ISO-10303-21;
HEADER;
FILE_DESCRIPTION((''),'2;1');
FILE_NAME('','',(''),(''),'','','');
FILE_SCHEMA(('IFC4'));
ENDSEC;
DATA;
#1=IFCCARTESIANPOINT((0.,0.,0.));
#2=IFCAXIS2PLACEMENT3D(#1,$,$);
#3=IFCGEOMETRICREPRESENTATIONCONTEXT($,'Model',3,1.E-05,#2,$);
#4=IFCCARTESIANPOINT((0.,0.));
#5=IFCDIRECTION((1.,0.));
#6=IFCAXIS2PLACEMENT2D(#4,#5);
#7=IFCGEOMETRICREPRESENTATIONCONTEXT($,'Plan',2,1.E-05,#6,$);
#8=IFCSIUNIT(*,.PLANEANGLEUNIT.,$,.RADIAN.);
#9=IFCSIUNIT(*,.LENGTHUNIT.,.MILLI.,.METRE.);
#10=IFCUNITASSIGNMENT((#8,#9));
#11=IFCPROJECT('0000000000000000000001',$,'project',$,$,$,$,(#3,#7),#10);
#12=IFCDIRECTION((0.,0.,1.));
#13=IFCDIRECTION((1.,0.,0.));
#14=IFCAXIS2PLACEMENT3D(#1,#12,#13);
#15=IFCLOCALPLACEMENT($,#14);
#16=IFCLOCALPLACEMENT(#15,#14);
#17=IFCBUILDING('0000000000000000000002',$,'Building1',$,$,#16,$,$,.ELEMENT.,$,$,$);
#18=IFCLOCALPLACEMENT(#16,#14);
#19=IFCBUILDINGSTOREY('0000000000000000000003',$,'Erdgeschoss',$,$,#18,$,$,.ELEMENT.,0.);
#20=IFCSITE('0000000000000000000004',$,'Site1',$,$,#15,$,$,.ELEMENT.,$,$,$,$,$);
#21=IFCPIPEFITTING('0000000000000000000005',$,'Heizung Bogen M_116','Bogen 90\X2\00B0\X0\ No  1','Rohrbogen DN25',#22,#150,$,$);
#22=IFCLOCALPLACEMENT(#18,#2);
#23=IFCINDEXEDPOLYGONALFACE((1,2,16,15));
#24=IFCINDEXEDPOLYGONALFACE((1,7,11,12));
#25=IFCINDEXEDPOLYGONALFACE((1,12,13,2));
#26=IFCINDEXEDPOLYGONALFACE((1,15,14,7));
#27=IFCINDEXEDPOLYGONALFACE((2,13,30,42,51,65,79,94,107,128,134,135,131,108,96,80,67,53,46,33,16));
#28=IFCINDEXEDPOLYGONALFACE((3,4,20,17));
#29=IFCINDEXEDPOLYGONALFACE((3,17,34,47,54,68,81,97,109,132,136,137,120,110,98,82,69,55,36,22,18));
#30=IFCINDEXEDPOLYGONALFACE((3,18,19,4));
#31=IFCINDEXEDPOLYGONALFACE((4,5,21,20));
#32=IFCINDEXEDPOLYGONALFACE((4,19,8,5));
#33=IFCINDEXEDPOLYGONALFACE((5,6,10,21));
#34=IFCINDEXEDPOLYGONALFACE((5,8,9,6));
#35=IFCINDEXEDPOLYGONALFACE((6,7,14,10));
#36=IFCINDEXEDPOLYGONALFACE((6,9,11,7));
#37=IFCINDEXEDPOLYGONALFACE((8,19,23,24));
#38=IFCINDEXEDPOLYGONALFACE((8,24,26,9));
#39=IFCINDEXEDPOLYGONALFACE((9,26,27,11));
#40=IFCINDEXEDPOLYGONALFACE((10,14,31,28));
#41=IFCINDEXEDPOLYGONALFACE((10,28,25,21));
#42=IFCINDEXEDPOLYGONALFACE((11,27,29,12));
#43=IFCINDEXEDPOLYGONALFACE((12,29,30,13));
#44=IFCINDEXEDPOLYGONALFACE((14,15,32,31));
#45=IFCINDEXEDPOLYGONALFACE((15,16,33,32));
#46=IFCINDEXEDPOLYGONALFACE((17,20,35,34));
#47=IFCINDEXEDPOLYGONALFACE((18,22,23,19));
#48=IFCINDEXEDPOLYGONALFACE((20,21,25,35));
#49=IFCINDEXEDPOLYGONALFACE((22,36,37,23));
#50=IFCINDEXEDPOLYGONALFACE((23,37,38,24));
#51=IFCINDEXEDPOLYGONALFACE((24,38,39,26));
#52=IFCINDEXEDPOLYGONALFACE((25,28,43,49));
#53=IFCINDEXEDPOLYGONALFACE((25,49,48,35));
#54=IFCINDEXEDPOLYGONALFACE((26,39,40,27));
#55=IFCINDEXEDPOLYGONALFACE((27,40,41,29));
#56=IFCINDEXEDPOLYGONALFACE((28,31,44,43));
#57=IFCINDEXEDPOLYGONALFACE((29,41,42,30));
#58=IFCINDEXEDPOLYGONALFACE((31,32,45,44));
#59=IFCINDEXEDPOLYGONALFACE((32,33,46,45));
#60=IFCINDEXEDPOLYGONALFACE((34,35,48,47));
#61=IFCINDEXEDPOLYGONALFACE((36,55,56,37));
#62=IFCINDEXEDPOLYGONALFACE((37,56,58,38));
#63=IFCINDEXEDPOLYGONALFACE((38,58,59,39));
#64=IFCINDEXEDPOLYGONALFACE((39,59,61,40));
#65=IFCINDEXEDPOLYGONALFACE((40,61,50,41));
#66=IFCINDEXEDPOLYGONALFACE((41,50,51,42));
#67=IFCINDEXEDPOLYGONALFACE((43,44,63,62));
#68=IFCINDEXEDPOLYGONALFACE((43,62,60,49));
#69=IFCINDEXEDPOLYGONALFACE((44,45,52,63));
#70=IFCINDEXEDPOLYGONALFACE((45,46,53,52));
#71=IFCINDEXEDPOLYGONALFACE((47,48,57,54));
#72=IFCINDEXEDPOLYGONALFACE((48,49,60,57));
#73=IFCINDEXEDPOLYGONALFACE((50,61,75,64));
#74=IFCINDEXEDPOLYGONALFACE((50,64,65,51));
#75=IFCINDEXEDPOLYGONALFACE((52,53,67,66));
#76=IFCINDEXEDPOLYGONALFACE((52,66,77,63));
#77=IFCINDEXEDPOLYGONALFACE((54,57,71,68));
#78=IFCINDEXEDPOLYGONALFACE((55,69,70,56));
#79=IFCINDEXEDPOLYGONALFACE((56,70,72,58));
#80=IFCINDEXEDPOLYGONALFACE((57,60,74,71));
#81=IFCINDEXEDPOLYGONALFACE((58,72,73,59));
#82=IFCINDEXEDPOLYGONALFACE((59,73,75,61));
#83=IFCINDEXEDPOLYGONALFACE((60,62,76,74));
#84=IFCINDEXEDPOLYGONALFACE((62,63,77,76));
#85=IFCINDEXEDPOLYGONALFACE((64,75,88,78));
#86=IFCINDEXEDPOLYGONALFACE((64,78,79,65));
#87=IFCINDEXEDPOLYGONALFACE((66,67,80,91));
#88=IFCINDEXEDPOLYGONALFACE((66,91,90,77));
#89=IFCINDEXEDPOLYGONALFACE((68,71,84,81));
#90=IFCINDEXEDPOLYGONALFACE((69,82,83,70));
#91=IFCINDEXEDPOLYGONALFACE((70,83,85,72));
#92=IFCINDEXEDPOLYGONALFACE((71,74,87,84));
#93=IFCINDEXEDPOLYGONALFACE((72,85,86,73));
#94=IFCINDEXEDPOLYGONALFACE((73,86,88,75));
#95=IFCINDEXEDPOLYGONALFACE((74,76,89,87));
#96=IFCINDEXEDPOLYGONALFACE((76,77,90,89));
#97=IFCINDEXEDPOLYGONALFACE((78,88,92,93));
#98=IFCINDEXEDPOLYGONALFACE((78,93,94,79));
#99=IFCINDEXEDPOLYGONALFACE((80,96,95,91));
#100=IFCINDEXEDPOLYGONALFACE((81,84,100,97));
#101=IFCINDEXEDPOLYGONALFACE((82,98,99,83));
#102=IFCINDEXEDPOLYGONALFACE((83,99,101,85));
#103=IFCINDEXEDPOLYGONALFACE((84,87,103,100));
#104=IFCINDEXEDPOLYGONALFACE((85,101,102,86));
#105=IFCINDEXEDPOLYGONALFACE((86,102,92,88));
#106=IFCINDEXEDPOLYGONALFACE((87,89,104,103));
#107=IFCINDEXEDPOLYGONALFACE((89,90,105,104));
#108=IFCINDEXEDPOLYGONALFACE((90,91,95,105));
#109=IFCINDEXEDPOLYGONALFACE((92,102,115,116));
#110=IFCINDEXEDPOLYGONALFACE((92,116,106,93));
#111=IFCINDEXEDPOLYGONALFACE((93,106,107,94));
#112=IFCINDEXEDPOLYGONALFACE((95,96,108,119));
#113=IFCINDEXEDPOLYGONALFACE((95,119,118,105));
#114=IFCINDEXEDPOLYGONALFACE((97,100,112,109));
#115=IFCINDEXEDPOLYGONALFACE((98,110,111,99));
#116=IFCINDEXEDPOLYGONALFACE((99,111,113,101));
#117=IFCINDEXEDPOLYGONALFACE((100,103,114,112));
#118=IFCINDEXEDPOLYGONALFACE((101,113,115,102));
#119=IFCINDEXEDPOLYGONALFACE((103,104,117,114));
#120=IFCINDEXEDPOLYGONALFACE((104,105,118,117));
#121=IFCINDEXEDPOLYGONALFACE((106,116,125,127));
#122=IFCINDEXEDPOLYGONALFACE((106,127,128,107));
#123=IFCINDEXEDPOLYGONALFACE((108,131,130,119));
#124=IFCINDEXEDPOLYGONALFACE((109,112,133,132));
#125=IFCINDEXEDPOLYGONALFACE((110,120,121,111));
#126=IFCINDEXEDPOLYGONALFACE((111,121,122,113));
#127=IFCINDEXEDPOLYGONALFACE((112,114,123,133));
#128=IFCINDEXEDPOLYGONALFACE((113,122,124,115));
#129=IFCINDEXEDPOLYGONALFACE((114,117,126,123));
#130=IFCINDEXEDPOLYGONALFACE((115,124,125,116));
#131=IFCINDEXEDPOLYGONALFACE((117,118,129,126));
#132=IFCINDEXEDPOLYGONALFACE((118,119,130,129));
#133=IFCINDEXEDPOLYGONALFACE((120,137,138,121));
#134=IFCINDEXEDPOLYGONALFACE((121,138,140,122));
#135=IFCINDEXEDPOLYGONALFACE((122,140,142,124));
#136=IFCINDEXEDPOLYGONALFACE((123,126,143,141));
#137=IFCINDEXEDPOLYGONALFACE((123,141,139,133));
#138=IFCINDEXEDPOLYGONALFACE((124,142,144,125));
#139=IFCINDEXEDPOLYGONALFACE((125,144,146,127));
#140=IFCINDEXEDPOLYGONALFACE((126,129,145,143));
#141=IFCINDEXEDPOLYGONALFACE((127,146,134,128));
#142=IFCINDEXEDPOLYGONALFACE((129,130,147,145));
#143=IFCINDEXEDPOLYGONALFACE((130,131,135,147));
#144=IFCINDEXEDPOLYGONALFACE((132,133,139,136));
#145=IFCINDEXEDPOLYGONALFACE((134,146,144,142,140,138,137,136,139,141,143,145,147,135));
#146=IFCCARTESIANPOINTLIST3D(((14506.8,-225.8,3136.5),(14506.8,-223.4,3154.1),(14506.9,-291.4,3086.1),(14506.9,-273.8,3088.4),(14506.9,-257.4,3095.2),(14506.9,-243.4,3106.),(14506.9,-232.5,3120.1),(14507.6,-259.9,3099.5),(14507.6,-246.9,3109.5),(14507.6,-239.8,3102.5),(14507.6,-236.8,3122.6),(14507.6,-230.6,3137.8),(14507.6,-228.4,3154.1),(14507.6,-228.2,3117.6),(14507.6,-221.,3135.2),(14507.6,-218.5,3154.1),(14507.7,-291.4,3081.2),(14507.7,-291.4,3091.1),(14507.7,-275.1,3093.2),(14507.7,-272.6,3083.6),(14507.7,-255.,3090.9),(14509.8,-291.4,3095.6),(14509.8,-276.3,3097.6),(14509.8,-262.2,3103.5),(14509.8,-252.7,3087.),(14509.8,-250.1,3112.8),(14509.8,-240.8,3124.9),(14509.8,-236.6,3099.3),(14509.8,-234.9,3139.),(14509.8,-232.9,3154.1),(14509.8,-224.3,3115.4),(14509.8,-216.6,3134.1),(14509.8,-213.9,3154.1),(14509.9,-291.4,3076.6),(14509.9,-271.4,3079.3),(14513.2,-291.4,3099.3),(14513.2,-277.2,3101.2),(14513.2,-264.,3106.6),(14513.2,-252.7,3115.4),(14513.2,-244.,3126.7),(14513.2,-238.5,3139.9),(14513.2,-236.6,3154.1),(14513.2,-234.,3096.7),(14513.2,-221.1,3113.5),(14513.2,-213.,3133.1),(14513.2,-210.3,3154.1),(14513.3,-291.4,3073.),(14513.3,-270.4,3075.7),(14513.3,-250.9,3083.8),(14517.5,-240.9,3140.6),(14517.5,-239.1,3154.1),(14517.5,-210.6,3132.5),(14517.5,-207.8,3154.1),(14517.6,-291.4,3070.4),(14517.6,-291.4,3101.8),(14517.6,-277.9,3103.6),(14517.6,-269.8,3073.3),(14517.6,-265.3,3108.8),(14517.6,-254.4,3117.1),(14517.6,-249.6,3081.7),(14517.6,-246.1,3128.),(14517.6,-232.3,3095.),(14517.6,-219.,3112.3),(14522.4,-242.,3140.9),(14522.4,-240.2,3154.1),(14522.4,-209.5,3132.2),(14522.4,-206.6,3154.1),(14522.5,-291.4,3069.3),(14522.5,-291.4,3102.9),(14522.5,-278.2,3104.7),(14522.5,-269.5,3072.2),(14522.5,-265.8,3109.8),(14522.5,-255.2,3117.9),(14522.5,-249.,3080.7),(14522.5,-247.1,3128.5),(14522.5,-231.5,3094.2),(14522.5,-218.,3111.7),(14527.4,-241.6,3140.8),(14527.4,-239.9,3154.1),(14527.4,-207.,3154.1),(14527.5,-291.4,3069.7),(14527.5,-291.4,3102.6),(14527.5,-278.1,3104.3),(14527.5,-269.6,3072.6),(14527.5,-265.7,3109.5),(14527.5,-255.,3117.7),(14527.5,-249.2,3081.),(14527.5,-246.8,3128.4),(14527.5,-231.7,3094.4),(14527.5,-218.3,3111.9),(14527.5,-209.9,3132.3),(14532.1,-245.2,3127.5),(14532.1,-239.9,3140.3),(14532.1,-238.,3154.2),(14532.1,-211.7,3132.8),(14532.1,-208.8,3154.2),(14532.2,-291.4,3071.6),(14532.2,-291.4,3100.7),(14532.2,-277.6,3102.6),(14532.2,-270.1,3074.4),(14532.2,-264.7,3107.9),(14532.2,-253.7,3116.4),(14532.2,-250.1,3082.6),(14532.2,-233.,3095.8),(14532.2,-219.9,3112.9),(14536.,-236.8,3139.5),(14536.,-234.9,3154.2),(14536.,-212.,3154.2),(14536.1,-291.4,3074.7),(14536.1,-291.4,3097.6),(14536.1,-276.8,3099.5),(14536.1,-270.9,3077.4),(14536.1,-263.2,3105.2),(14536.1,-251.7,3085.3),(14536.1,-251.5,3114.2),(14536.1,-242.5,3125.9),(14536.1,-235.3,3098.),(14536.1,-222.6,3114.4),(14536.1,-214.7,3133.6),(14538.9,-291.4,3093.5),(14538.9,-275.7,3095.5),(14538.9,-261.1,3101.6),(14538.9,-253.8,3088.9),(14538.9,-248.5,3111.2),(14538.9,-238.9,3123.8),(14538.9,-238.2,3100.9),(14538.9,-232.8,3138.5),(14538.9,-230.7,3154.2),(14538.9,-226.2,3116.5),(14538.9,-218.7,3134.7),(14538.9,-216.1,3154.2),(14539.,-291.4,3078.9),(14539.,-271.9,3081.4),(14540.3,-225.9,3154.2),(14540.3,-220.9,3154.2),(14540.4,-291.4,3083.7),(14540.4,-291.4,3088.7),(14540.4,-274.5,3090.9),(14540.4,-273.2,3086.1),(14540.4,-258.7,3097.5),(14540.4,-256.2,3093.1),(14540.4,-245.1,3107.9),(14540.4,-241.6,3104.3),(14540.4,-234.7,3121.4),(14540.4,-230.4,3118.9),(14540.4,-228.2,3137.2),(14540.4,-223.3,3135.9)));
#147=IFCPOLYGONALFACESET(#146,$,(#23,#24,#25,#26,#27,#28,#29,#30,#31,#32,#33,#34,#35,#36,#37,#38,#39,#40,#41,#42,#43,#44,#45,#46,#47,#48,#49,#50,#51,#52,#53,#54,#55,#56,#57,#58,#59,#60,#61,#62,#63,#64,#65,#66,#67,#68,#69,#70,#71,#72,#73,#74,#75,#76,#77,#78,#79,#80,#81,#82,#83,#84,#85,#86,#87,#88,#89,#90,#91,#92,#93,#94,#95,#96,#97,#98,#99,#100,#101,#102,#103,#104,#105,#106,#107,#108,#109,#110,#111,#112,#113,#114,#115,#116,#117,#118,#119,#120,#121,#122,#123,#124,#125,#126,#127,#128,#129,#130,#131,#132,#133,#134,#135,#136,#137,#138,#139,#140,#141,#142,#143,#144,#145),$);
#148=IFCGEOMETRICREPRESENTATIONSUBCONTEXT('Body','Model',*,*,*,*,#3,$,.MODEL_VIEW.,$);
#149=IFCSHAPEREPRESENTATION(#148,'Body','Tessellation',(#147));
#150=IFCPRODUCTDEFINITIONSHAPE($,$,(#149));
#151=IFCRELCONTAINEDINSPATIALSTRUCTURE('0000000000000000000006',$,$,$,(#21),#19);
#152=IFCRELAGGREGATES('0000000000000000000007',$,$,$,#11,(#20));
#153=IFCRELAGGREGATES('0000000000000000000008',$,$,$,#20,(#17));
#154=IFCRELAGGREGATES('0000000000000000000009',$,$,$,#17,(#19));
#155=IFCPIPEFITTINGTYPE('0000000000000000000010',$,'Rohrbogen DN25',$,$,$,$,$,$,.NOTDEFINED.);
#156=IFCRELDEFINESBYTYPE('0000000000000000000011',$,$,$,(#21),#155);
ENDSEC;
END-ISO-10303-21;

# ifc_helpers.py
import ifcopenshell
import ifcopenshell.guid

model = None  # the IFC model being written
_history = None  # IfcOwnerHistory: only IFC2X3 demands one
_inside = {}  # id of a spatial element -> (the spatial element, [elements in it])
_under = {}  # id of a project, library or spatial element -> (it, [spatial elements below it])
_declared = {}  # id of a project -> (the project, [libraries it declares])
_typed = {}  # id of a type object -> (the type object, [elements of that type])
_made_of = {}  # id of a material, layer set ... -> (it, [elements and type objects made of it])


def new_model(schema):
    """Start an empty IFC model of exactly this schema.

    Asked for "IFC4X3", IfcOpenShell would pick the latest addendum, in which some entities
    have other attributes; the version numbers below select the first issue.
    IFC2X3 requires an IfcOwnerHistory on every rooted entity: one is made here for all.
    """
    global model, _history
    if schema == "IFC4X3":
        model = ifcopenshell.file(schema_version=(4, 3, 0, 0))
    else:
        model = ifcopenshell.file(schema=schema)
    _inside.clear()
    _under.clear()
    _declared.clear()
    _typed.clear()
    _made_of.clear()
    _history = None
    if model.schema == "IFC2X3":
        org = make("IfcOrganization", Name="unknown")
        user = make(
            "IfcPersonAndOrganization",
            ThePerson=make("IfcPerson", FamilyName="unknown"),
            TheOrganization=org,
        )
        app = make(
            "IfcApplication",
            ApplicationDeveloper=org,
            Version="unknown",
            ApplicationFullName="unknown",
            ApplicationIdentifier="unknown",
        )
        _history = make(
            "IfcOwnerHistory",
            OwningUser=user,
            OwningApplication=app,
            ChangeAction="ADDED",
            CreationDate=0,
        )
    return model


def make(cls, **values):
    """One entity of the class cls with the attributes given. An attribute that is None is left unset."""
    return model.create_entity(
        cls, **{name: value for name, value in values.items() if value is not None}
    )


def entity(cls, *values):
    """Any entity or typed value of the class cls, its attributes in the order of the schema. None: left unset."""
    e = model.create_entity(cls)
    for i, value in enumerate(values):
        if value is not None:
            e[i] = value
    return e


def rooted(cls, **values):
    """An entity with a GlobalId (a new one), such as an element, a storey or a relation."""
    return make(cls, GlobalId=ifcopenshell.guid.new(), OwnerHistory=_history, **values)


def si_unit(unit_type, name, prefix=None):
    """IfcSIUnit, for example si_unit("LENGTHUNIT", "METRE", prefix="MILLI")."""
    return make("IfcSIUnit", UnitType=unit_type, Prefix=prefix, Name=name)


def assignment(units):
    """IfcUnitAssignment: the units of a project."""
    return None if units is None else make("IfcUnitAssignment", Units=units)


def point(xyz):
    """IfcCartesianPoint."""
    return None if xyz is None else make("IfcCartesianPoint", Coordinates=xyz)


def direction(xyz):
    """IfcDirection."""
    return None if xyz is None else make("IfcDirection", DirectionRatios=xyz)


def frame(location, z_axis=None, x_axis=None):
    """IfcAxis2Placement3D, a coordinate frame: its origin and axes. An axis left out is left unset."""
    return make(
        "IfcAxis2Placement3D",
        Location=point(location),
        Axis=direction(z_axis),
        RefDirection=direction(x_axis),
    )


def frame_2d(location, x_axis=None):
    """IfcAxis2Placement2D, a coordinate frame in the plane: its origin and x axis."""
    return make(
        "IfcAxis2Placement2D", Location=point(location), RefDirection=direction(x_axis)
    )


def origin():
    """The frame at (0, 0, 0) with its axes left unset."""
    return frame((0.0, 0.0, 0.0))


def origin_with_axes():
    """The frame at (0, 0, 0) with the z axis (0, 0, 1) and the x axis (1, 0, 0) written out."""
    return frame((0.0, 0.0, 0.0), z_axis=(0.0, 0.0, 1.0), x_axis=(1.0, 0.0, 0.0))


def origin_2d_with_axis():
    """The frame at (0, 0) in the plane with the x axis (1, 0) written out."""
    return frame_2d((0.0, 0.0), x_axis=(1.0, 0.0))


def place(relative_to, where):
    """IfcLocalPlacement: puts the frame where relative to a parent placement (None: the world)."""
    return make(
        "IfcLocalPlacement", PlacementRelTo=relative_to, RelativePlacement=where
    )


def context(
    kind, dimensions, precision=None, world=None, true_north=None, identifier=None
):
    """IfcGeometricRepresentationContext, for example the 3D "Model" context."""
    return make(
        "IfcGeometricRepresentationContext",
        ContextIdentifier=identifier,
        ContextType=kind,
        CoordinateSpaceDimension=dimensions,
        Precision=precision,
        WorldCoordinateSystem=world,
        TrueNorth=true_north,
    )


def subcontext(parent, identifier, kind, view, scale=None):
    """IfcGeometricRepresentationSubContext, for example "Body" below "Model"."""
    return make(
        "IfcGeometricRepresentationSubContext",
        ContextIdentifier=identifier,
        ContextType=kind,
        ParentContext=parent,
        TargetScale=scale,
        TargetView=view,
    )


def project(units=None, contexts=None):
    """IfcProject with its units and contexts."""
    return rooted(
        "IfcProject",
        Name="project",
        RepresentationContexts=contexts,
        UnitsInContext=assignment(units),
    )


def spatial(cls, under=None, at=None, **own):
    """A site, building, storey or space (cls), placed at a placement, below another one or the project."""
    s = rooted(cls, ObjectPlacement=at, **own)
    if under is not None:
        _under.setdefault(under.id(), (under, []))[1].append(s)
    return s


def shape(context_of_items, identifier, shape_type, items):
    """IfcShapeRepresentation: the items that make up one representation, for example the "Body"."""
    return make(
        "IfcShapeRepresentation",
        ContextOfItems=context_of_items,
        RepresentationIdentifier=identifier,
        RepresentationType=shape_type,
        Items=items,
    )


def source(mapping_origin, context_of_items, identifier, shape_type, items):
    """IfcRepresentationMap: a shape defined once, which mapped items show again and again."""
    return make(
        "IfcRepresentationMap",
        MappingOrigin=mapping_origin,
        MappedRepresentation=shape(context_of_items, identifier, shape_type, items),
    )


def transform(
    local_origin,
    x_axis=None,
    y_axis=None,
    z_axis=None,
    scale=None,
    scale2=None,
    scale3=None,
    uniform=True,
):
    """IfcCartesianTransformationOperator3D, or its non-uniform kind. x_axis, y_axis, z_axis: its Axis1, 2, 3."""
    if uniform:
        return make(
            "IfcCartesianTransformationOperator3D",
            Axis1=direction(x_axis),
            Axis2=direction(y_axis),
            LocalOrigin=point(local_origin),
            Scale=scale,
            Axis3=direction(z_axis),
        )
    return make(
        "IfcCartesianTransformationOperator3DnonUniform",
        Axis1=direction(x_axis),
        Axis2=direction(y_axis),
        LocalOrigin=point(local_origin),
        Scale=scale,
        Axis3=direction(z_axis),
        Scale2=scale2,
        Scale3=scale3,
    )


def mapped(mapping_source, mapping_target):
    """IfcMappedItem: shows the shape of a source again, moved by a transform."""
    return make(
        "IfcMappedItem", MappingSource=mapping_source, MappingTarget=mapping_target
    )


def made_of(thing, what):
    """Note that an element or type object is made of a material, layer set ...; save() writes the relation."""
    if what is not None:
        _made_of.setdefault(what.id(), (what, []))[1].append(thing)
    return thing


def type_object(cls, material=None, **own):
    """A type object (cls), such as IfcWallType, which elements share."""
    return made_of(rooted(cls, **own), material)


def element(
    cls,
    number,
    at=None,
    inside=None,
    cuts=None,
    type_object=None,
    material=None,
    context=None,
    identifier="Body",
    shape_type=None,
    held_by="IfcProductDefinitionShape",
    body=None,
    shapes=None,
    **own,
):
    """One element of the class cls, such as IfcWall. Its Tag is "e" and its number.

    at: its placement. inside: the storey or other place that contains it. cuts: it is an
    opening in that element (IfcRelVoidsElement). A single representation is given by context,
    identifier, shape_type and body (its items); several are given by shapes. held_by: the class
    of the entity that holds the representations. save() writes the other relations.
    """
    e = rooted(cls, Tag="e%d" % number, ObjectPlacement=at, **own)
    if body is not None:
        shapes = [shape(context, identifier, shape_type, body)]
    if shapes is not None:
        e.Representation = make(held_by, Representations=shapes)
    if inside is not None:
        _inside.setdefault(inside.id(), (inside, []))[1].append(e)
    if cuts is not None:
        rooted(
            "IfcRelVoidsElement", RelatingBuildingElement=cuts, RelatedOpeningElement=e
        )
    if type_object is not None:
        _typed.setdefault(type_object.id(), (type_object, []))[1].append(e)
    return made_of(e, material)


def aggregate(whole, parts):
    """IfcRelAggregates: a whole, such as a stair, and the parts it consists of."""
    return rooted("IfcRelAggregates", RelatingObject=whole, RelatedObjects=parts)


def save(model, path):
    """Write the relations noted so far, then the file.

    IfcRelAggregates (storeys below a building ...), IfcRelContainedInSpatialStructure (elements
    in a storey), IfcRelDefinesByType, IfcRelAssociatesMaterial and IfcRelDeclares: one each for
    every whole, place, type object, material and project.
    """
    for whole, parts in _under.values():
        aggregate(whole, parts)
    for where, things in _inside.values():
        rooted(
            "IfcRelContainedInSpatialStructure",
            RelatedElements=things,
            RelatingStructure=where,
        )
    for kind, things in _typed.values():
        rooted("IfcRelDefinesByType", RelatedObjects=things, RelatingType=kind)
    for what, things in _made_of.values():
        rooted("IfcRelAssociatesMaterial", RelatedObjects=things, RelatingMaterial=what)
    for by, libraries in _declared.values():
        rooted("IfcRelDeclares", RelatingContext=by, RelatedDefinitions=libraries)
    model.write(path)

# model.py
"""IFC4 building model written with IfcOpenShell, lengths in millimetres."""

from ifc_helpers import new_model, entity, si_unit, frame, origin, origin_with_axes, origin_2d_with_axis, place, context, subcontext, project, spatial, source, transform, mapped, type_object, element, save


model = new_model("IFC4")

# Units and contexts
model_context = context("Model", 3, precision=1e-05, world=origin())
plan_context = context("Plan", 2, precision=1e-05, world=origin_2d_with_axis())
body_context = subcontext(model_context, "Body", "Model", "MODEL_VIEW")
ifc_project = project(units=[si_unit("PLANEANGLEUNIT", "RADIAN"), si_unit("LENGTHUNIT", "METRE", prefix="MILLI")], contexts=[model_context, plan_context])

# Site, building, storey
site_placement = place(None, origin_with_axes())
site = spatial("IfcSite", under=ifc_project, at=site_placement, Name="Site1", CompositionType="ELEMENT")
building_placement = place(site_placement, origin_with_axes())
building = spatial("IfcBuilding", under=site, at=building_placement, Name="Building1", CompositionType="ELEMENT")
storey_placement = place(building_placement, origin_with_axes())
storey = spatial("IfcBuildingStorey", under=building, at=storey_placement, Name="Erdgeschoss", CompositionType="ELEMENT", Elevation=0.0)

# Pipe fitting
pipe_fitting_type = type_object("IfcPipeFittingType", Name="Rohrbogen DN25", PredefinedType="NOTDEFINED")
shared_shape_1 = source(origin_with_axes(), body_context, "Body", "SolidModel", [
    entity("IfcRevolvedAreaSolid", entity("IfcCircleProfileDef", "AREA", None, entity("IfcAxis2Placement2D", entity("IfcCartesianPoint", [0.0, 0.0]), entity("IfcDirection", [1.0, 0.0])), 16.9), entity("IfcAxis2Placement3D", entity("IfcCartesianPoint", [-42.4, 0.1, 25.6]), entity("IfcDirection", [1.0, 0.0, 0.0]), entity("IfcDirection", [0.0, -0.999997, 0.002343])), entity("IfcAxis1Placement", entity("IfcCartesianPoint", [0.0, 68.0, 0.0]), entity("IfcDirection", [-1.0, 0.0, 0.0])), 1.570796),
])
pipe_fitting_1_placement = place(storey_placement, frame((14523.7, -249.0, 3111.7), z_axis=(0.0, 0.0, 1.0), x_axis=(1.0, 0.0, 0.0)))
element("IfcPipeFitting", 1, at=pipe_fitting_1_placement, inside=storey, type_object=pipe_fitting_type, Name="Heizung Bogen M_116", Description="Bogen 90° No  1", ObjectType="Rohrbogen DN25", context=body_context, shape_type="MappedRepresentation", body=[
    mapped(shared_shape_1, transform((0.0, 0.0, 0.0), x_axis=(0.000001, 1.0, 0.0), y_axis=(1.0, -0.000001, -0.000979), z_axis=(-0.000979, 0.0, -1.0), scale=1.0)),
])

save(model, "model.ifc")
